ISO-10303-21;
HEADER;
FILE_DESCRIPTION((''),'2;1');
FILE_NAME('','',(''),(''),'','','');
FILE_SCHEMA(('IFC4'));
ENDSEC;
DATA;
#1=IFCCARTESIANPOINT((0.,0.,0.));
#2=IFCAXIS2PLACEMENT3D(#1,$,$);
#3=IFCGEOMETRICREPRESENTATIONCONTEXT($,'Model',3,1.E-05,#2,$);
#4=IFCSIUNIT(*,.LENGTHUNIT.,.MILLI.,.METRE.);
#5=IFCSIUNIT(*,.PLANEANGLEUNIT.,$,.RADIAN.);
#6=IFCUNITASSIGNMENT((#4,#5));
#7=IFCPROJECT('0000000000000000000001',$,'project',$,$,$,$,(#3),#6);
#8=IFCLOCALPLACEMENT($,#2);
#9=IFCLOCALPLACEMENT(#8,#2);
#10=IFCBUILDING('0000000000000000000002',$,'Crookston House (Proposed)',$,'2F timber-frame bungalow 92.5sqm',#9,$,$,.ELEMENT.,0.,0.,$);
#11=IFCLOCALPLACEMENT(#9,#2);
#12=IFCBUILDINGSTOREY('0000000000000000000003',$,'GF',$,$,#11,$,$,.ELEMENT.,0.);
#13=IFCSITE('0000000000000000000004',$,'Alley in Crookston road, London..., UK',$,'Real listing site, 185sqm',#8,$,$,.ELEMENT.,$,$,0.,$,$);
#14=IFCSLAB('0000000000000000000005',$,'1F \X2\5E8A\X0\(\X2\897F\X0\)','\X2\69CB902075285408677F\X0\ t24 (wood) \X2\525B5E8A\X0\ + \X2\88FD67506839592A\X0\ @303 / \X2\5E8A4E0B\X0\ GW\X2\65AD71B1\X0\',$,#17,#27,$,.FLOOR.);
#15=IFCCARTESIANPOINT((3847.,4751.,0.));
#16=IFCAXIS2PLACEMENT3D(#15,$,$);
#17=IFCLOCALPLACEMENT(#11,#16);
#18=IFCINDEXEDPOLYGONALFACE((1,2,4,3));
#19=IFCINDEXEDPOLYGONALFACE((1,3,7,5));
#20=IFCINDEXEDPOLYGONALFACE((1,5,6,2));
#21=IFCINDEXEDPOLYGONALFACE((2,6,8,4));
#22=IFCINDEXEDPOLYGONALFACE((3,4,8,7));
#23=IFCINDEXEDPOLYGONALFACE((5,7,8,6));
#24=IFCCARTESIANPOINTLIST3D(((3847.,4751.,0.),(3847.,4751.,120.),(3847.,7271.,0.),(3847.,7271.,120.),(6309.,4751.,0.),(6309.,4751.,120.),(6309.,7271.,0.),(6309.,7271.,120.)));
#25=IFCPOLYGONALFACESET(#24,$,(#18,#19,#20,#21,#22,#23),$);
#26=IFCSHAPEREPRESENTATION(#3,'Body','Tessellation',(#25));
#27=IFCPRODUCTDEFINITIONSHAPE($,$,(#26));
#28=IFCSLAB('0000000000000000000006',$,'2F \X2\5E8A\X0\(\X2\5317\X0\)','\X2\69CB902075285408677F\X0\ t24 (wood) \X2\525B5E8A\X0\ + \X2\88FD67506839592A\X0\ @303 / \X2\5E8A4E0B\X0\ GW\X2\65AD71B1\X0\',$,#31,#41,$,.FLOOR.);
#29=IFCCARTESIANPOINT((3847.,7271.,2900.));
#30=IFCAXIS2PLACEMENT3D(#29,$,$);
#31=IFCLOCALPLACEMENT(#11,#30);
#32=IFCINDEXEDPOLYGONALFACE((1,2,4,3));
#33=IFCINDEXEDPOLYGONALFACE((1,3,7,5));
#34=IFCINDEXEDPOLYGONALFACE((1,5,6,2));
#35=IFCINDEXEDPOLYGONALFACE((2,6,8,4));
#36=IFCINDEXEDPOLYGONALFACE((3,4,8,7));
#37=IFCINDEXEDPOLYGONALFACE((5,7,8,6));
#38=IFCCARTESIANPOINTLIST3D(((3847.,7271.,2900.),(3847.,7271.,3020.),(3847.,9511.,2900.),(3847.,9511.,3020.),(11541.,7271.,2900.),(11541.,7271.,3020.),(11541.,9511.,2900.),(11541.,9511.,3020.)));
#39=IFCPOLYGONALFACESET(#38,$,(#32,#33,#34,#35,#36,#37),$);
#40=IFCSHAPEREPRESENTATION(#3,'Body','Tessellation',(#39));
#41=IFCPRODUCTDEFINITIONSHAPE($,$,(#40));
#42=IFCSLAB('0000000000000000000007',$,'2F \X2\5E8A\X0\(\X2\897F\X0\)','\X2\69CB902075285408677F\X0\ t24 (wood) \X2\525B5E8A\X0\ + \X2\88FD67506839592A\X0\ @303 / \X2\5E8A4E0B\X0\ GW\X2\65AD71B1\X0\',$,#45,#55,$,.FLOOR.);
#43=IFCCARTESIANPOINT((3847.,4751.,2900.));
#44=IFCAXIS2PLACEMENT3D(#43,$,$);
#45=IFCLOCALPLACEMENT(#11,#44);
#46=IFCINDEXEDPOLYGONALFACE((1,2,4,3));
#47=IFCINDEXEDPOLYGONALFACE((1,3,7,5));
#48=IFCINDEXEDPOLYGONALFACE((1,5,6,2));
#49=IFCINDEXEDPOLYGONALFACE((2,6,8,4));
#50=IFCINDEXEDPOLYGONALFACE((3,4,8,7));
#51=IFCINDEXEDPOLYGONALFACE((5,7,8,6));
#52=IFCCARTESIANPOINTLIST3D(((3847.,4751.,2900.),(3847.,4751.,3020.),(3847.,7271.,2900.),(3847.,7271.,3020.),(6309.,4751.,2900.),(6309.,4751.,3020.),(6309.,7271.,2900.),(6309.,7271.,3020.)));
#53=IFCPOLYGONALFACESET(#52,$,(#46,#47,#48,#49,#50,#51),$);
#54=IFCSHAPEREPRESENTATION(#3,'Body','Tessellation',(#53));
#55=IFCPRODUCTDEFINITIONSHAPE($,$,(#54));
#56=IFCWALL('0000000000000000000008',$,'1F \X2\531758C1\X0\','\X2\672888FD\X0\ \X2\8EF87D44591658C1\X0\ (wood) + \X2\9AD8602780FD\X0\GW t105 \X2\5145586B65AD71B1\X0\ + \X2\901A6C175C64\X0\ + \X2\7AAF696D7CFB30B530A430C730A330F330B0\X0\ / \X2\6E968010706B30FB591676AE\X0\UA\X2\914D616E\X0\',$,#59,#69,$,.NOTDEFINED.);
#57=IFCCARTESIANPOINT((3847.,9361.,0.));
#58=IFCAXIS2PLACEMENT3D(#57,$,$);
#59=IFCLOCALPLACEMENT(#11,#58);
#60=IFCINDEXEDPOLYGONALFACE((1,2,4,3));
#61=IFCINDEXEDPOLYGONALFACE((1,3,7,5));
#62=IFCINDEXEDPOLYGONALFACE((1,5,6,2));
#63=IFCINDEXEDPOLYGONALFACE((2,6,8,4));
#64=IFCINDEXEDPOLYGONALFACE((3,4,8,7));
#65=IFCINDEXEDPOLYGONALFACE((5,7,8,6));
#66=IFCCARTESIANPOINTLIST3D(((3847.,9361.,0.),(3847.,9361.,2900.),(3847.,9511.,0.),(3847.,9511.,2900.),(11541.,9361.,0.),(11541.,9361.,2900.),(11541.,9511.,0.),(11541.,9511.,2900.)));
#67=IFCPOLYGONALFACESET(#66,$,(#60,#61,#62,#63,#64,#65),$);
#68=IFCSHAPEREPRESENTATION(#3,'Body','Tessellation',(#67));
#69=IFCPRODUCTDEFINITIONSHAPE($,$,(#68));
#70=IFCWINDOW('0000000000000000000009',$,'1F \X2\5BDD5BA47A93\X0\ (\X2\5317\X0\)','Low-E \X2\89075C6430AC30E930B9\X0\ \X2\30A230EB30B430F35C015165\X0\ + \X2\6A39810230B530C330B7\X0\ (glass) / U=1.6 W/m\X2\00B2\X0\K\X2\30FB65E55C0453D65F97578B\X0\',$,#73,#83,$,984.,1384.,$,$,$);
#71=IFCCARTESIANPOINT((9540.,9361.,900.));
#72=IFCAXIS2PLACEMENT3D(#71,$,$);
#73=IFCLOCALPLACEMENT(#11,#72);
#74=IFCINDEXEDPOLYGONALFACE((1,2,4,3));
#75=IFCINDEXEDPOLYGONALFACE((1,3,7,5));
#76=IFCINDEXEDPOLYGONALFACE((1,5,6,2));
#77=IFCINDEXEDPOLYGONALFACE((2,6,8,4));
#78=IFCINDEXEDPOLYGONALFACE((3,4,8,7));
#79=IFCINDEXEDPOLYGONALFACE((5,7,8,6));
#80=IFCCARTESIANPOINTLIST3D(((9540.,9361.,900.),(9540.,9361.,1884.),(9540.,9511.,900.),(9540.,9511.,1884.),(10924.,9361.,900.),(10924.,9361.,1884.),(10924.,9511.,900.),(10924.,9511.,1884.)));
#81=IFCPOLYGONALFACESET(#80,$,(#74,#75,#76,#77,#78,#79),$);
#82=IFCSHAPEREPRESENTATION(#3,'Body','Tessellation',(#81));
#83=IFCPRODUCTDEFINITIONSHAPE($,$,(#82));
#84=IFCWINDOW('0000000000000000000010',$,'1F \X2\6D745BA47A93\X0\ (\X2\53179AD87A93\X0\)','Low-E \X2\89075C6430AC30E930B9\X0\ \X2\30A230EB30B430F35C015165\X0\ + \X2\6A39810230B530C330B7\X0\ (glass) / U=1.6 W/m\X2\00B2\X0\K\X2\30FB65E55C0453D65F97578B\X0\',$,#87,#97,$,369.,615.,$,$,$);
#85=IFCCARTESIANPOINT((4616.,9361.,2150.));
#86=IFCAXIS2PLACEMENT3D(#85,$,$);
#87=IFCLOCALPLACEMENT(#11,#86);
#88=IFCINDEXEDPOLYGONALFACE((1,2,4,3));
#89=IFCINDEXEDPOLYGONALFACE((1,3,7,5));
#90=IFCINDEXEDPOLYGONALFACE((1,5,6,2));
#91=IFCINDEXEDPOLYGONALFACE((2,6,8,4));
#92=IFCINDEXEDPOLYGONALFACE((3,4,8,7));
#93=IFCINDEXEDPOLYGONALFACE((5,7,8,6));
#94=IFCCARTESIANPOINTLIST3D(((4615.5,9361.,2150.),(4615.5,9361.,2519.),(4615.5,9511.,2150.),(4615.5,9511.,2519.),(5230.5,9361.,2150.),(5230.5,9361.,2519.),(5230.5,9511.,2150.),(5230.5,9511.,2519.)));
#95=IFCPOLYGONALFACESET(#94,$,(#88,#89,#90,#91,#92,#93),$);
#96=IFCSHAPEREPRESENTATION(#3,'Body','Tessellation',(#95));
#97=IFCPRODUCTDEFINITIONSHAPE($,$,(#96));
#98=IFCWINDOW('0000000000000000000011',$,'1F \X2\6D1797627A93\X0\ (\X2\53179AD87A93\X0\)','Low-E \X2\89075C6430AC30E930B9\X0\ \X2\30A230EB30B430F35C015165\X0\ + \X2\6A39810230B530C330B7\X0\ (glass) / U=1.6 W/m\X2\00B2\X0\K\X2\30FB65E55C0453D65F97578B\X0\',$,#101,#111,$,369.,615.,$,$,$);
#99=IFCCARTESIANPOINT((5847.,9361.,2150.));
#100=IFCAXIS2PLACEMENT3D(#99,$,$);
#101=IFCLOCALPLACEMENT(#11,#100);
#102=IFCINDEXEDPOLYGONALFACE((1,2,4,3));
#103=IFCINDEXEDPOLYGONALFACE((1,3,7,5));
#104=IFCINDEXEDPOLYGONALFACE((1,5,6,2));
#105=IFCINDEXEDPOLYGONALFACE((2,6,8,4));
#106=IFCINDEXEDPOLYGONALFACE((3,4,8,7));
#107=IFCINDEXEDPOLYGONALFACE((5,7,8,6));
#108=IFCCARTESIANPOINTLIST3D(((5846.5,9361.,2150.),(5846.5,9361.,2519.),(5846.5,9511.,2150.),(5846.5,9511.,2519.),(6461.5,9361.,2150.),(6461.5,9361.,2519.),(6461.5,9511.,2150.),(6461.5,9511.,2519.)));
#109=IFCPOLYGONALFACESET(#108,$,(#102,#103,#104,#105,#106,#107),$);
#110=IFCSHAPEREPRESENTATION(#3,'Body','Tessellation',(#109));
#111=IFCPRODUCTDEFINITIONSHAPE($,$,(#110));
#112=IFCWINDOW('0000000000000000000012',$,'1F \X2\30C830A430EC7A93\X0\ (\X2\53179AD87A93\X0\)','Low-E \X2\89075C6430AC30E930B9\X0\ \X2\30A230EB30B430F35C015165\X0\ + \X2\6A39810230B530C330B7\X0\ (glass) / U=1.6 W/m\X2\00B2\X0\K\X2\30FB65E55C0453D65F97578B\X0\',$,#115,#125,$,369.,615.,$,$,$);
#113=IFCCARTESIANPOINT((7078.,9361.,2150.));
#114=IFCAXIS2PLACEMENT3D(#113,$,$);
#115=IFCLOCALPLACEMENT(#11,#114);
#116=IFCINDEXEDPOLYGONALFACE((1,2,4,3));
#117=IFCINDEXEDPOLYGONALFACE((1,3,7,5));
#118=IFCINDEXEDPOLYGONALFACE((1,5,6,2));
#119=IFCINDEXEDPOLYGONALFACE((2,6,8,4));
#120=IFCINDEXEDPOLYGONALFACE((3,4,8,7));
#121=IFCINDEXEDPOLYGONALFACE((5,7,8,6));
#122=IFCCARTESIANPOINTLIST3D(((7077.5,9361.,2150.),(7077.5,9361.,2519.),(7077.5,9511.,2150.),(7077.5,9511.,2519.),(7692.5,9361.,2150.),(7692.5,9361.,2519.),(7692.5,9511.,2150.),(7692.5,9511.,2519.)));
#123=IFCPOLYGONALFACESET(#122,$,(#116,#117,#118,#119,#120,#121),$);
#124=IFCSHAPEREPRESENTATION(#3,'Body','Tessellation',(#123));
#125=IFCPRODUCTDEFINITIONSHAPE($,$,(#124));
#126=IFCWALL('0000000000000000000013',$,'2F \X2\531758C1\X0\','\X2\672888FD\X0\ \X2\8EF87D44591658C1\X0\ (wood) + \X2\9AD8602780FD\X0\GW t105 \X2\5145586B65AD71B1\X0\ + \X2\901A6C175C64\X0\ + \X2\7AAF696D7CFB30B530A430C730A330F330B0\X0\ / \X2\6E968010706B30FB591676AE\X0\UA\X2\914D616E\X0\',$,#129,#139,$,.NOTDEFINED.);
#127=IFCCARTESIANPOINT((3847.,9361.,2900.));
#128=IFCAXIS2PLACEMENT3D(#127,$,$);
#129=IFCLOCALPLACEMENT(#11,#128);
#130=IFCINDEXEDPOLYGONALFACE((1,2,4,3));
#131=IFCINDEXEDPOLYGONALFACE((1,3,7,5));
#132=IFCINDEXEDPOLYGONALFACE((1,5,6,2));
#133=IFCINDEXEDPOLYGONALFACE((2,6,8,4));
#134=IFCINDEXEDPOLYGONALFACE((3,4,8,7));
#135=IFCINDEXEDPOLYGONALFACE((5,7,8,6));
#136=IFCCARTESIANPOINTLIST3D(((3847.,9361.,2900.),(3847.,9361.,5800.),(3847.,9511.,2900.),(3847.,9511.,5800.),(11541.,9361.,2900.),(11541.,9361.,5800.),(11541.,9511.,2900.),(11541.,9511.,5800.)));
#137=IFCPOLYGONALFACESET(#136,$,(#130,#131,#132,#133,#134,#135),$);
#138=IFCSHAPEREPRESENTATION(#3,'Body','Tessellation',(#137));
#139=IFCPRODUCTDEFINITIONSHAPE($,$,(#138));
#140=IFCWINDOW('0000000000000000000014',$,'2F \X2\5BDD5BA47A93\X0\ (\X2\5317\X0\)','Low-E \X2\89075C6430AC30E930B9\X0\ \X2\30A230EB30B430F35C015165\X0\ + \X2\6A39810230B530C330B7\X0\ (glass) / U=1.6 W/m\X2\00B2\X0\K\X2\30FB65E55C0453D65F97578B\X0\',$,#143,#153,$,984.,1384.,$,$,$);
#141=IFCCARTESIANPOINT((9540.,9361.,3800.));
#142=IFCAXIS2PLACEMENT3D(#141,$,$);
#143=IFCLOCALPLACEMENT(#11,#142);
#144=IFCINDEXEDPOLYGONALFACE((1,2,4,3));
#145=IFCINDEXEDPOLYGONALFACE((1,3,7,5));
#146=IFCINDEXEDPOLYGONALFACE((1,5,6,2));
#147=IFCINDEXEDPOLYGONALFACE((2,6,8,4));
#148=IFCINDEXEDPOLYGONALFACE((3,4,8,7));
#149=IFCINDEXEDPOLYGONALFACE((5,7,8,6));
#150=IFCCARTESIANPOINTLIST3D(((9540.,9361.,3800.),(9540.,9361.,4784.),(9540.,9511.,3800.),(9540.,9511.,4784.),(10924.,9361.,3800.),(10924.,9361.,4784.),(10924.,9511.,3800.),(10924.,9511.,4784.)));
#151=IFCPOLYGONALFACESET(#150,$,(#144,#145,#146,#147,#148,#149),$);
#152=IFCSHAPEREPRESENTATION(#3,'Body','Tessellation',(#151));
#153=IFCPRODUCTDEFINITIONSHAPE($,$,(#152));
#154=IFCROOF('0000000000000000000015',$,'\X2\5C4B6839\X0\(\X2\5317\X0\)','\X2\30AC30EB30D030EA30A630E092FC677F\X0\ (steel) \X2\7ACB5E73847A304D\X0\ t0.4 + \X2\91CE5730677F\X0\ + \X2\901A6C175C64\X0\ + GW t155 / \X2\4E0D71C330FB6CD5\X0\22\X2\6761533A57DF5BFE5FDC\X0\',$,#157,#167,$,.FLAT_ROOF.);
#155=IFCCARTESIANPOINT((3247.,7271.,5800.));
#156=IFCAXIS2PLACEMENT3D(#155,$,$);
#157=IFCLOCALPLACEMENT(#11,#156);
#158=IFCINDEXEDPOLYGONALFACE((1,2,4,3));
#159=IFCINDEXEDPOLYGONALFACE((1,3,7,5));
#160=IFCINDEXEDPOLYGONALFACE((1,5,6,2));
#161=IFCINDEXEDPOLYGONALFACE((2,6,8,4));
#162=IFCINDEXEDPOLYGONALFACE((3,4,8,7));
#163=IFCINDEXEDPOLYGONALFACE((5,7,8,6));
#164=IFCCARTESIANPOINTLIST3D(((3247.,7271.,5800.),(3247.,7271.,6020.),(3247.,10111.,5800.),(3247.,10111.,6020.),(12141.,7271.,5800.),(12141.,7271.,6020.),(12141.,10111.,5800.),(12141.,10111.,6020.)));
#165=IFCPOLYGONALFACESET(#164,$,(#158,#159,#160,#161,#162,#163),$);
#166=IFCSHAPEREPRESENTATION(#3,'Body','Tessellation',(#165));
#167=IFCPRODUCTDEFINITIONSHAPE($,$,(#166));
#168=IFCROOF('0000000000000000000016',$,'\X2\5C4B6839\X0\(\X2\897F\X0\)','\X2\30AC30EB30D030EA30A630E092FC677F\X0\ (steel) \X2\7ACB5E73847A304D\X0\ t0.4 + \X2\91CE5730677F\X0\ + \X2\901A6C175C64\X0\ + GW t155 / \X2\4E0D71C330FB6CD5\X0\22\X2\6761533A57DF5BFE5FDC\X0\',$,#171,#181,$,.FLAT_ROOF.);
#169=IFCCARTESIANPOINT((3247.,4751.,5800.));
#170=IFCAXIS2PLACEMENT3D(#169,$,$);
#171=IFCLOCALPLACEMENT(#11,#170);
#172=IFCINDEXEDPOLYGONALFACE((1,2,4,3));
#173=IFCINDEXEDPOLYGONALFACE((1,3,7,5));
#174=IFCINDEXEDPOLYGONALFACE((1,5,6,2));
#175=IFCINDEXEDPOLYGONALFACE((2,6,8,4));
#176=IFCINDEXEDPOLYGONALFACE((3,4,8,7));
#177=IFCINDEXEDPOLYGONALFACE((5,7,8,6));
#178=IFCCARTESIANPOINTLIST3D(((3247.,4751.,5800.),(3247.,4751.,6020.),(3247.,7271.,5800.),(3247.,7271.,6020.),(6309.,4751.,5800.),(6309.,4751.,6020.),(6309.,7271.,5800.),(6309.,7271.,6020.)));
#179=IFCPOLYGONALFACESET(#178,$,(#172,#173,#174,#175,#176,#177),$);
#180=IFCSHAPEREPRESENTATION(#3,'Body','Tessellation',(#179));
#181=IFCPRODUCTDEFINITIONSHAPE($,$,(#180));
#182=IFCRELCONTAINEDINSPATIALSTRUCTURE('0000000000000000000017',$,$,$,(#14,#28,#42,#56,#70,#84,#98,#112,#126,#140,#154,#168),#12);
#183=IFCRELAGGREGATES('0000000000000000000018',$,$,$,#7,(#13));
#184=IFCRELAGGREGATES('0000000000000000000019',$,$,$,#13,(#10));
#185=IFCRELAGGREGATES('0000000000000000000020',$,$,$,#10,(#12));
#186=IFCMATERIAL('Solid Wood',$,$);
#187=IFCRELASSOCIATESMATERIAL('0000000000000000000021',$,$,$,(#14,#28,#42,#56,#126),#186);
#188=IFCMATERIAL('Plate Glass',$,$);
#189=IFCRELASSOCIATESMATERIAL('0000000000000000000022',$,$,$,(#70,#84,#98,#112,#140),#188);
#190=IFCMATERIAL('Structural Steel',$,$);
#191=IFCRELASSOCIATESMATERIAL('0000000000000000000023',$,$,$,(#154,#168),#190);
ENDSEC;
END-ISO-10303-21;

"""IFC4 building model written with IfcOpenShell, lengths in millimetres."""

from ifc_helpers import new_model, si_unit, frame, frame_2d, origin, place, context, project, spatial, rectangle, extrude, material, element, fill, save


model = new_model("IFC4")

# Units and contexts
model_context = context("Model", 3, precision=1e-05, world=origin())
ifc_project = project(units=[si_unit("LENGTHUNIT", "METRE", prefix="MILLI"), si_unit("PLANEANGLEUNIT", "RADIAN")], contexts=[model_context])

# Site, building, storey
site_placement = place(None, origin())
site = spatial("IfcSite", under=ifc_project, at=site_placement, Name="Alley in Crookston road, London..., UK", ObjectType="Real listing site, 185sqm", CompositionType="ELEMENT", RefElevation=0.0)
building_placement = place(site_placement, origin())
building = spatial("IfcBuilding", under=site, at=building_placement, Name="Crookston House (Proposed)", ObjectType="2F timber-frame bungalow 92.5sqm", CompositionType="ELEMENT", ElevationOfRefHeight=0.0, ElevationOfTerrain=0.0)
storey_placement = place(building_placement, origin())
storey = spatial("IfcBuildingStorey", under=building, at=storey_placement, Name="GF", CompositionType="ELEMENT", Elevation=0.0)

# Slabs
ifc_material_1 = material(Name="Solid Wood")
slab_1_placement = place(storey_placement, frame((3847.0, 4751.0, 0.0)))
element("IfcSlab", 1, at=slab_1_placement, inside=storey, material=ifc_material_1, Name="1F 床(西)", Description="構造用合板 t24 (wood) 剛床 + 製材根太 @303 / 床下 GW断熱", PredefinedType="FLOOR", context=model_context, shape_type="SweptSolid", body=[
    extrude(rectangle(XDim=2462.0, YDim=2520.0, at=frame_2d((1231.0, 1260.0))), frame((3847.0, 4751.0, 0.0)), (0.0, 0.0, 1.0), 120.0),
])
slab_2_placement = place(storey_placement, frame((3847.0, 7271.0, 2900.0)))
element("IfcSlab", 2, at=slab_2_placement, inside=storey, material=ifc_material_1, Name="2F 床(北)", Description="構造用合板 t24 (wood) 剛床 + 製材根太 @303 / 床下 GW断熱", PredefinedType="FLOOR", context=model_context, shape_type="SweptSolid", body=[
    extrude(rectangle(XDim=7694.0, YDim=2240.0, at=frame_2d((3847.0, 1120.0))), frame((3847.0, 7271.0, 2900.0)), (0.0, 0.0, 1.0), 120.0),
])
slab_3_placement = place(storey_placement, frame((3847.0, 4751.0, 2900.0)))
element("IfcSlab", 3, at=slab_3_placement, inside=storey, material=ifc_material_1, Name="2F 床(西)", Description="構造用合板 t24 (wood) 剛床 + 製材根太 @303 / 床下 GW断熱", PredefinedType="FLOOR", context=model_context, shape_type="SweptSolid", body=[
    extrude(rectangle(XDim=2462.0, YDim=2520.0, at=frame_2d((1231.0, 1260.0))), frame((3847.0, 4751.0, 2900.0)), (0.0, 0.0, 1.0), 120.0),
])

# Wall, openings, windows
wall_1_placement = place(storey_placement, frame((3847.0, 9361.0, 0.0)))
wall_1 = element("IfcWall", 4, at=wall_1_placement, inside=storey, material=ifc_material_1, Name="1F 北壁", Description="木製 軸組外壁 (wood) + 高性能GW t105 充填断熱 + 通気層 + 窯業系サイディング / 準耐火・外皮UA配慮", PredefinedType="NOTDEFINED", context=model_context, shape_type="SweptSolid", body=[
    extrude(rectangle(XDim=7694.0, YDim=150.0, at=frame_2d((3847.0, 75.0))), frame((3847.0, 9361.0, 0.0)), (0.0, 0.0, 1.0), 2900.0),
])
opening_1_placement = place(storey_placement, frame((9540.0, 9361.0, 900.0)))
opening_1 = element("IfcOpeningElement", 5, at=opening_1_placement, cuts=wall_1, PredefinedType="NOTDEFINED", context=model_context, shape_type="SweptSolid", body=[
    extrude(rectangle(XDim=1384.0, YDim=150.0, at=frame_2d((692.0, 75.0))), frame((9540.0, 9361.0, 900.0)), (0.0, 0.0, 1.0), 984.0),
])
opening_2_placement = place(storey_placement, frame((4616.0, 9361.0, 2150.0)))
opening_2 = element("IfcOpeningElement", 6, at=opening_2_placement, cuts=wall_1, PredefinedType="NOTDEFINED", context=model_context, shape_type="SweptSolid", body=[
    extrude(rectangle(XDim=615.0, YDim=150.0, at=frame_2d((307.0, 75.0))), frame((4616.0, 9361.0, 2150.0)), (0.0, 0.0, 1.0), 369.0),
])
opening_3_placement = place(storey_placement, frame((5847.0, 9361.0, 2150.0)))
opening_3 = element("IfcOpeningElement", 7, at=opening_3_placement, cuts=wall_1, PredefinedType="NOTDEFINED", context=model_context, shape_type="SweptSolid", body=[
    extrude(rectangle(XDim=615.0, YDim=150.0, at=frame_2d((307.0, 75.0))), frame((5847.0, 9361.0, 2150.0)), (0.0, 0.0, 1.0), 369.0),
])
opening_4_placement = place(storey_placement, frame((7078.0, 9361.0, 2150.0)))
opening_4 = element("IfcOpeningElement", 8, at=opening_4_placement, cuts=wall_1, PredefinedType="NOTDEFINED", context=model_context, shape_type="SweptSolid", body=[
    extrude(rectangle(XDim=615.0, YDim=150.0, at=frame_2d((307.0, 75.0))), frame((7078.0, 9361.0, 2150.0)), (0.0, 0.0, 1.0), 369.0),
])
ifc_material_2 = material(Name="Plate Glass")
window_1_placement = place(storey_placement, frame((9540.0, 9361.0, 900.0)))
window_1 = element("IfcWindow", 9, at=window_1_placement, inside=storey, material=ifc_material_2, Name="1F 寝室窓 (北)", Description="Low-E 複層ガラス アルゴン封入 + 樹脂サッシ (glass) / U=1.6 W/m²K・日射取得型", OverallHeight=984.0, OverallWidth=1384.0, context=model_context, shape_type="SweptSolid", body=[
    extrude(rectangle(XDim=1384.0, YDim=150.0, at=frame_2d((692.0, 75.0))), frame((9540.0, 9361.0, 900.0)), (0.0, 0.0, 1.0), 984.0),
])
fill(opening_1, window_1)
window_2_placement = place(storey_placement, frame((4616.0, 9361.0, 2150.0)))
window_2 = element("IfcWindow", 10, at=window_2_placement, inside=storey, material=ifc_material_2, Name="1F 浴室窓 (北高窓)", Description="Low-E 複層ガラス アルゴン封入 + 樹脂サッシ (glass) / U=1.6 W/m²K・日射取得型", OverallHeight=369.0, OverallWidth=615.0, context=model_context, shape_type="SweptSolid", body=[
    extrude(rectangle(XDim=615.0, YDim=150.0, at=frame_2d((307.0, 75.0))), frame((4616.0, 9361.0, 2150.0)), (0.0, 0.0, 1.0), 369.0),
])
fill(opening_2, window_2)
window_3_placement = place(storey_placement, frame((5847.0, 9361.0, 2150.0)))
window_3 = element("IfcWindow", 11, at=window_3_placement, inside=storey, material=ifc_material_2, Name="1F 洗面窓 (北高窓)", Description="Low-E 複層ガラス アルゴン封入 + 樹脂サッシ (glass) / U=1.6 W/m²K・日射取得型", OverallHeight=369.0, OverallWidth=615.0, context=model_context, shape_type="SweptSolid", body=[
    extrude(rectangle(XDim=615.0, YDim=150.0, at=frame_2d((307.0, 75.0))), frame((5847.0, 9361.0, 2150.0)), (0.0, 0.0, 1.0), 369.0),
])
fill(opening_3, window_3)
window_4_placement = place(storey_placement, frame((7078.0, 9361.0, 2150.0)))
window_4 = element("IfcWindow", 12, at=window_4_placement, inside=storey, material=ifc_material_2, Name="1F トイレ窓 (北高窓)", Description="Low-E 複層ガラス アルゴン封入 + 樹脂サッシ (glass) / U=1.6 W/m²K・日射取得型", OverallHeight=369.0, OverallWidth=615.0, context=model_context, shape_type="SweptSolid", body=[
    extrude(rectangle(XDim=615.0, YDim=150.0, at=frame_2d((307.0, 75.0))), frame((7078.0, 9361.0, 2150.0)), (0.0, 0.0, 1.0), 369.0),
])
fill(opening_4, window_4)

# Wall, opening, window
wall_2_placement = place(storey_placement, frame((3847.0, 9361.0, 2900.0)))
wall_2 = element("IfcWall", 13, at=wall_2_placement, inside=storey, material=ifc_material_1, Name="2F 北壁", Description="木製 軸組外壁 (wood) + 高性能GW t105 充填断熱 + 通気層 + 窯業系サイディング / 準耐火・外皮UA配慮", PredefinedType="NOTDEFINED", context=model_context, shape_type="SweptSolid", body=[
    extrude(rectangle(XDim=7694.0, YDim=150.0, at=frame_2d((3847.0, 75.0))), frame((3847.0, 9361.0, 2900.0)), (0.0, 0.0, 1.0), 2900.0),
])
opening_5_placement = place(storey_placement, frame((9540.0, 9361.0, 3800.0)))
opening_5 = element("IfcOpeningElement", 14, at=opening_5_placement, cuts=wall_2, PredefinedType="NOTDEFINED", context=model_context, shape_type="SweptSolid", body=[
    extrude(rectangle(XDim=1384.0, YDim=150.0, at=frame_2d((692.0, 75.0))), frame((9540.0, 9361.0, 3800.0)), (0.0, 0.0, 1.0), 984.0),
])
window_5_placement = place(storey_placement, frame((9540.0, 9361.0, 3800.0)))
window_5 = element("IfcWindow", 15, at=window_5_placement, inside=storey, material=ifc_material_2, Name="2F 寝室窓 (北)", Description="Low-E 複層ガラス アルゴン封入 + 樹脂サッシ (glass) / U=1.6 W/m²K・日射取得型", OverallHeight=984.0, OverallWidth=1384.0, context=model_context, shape_type="SweptSolid", body=[
    extrude(rectangle(XDim=1384.0, YDim=150.0, at=frame_2d((692.0, 75.0))), frame((9540.0, 9361.0, 3800.0)), (0.0, 0.0, 1.0), 984.0),
])
fill(opening_5, window_5)

# Roofs
ifc_material_3 = material(Name="Structural Steel")
for number, where, name in (
    (16, (3247.0, 7271.0, 5800.0), "屋根(北)"),
):
    element("IfcRoof", number, at=place(storey_placement, frame(where)), inside=storey, material=ifc_material_3, Name=name, Description="ガルバリウム鋼板 (steel) 立平葺き t0.4 + 野地板 + 通気層 + GW t155 / 不燃・法22条区域対応", PredefinedType="FLAT_ROOF", context=model_context, shape_type="SweptSolid", body=[
        extrude(rectangle(XDim=8894.0, YDim=2840.0, at=frame_2d((4447.0, 1420.0))), frame((3247.0, 7271.0, 5800.0)), (0.0, 0.0, 1.0), 220.0),
    ])
roof_placement = place(storey_placement, frame((3247.0, 4751.0, 5800.0)))
element("IfcRoof", 17, at=roof_placement, inside=storey, material=ifc_material_3, Name="屋根(西)", Description="ガルバリウム鋼板 (steel) 立平葺き t0.4 + 野地板 + 通気層 + GW t155 / 不燃・法22条区域対応", PredefinedType="FLAT_ROOF", context=model_context, shape_type="SweptSolid", body=[
    extrude(rectangle(XDim=3062.0, YDim=2520.0, at=frame_2d((1531.0, 1260.0))), frame((3247.0, 4751.0, 5800.0)), (0.0, 0.0, 1.0), 220.0),
])

save(model, "model.ifc")
